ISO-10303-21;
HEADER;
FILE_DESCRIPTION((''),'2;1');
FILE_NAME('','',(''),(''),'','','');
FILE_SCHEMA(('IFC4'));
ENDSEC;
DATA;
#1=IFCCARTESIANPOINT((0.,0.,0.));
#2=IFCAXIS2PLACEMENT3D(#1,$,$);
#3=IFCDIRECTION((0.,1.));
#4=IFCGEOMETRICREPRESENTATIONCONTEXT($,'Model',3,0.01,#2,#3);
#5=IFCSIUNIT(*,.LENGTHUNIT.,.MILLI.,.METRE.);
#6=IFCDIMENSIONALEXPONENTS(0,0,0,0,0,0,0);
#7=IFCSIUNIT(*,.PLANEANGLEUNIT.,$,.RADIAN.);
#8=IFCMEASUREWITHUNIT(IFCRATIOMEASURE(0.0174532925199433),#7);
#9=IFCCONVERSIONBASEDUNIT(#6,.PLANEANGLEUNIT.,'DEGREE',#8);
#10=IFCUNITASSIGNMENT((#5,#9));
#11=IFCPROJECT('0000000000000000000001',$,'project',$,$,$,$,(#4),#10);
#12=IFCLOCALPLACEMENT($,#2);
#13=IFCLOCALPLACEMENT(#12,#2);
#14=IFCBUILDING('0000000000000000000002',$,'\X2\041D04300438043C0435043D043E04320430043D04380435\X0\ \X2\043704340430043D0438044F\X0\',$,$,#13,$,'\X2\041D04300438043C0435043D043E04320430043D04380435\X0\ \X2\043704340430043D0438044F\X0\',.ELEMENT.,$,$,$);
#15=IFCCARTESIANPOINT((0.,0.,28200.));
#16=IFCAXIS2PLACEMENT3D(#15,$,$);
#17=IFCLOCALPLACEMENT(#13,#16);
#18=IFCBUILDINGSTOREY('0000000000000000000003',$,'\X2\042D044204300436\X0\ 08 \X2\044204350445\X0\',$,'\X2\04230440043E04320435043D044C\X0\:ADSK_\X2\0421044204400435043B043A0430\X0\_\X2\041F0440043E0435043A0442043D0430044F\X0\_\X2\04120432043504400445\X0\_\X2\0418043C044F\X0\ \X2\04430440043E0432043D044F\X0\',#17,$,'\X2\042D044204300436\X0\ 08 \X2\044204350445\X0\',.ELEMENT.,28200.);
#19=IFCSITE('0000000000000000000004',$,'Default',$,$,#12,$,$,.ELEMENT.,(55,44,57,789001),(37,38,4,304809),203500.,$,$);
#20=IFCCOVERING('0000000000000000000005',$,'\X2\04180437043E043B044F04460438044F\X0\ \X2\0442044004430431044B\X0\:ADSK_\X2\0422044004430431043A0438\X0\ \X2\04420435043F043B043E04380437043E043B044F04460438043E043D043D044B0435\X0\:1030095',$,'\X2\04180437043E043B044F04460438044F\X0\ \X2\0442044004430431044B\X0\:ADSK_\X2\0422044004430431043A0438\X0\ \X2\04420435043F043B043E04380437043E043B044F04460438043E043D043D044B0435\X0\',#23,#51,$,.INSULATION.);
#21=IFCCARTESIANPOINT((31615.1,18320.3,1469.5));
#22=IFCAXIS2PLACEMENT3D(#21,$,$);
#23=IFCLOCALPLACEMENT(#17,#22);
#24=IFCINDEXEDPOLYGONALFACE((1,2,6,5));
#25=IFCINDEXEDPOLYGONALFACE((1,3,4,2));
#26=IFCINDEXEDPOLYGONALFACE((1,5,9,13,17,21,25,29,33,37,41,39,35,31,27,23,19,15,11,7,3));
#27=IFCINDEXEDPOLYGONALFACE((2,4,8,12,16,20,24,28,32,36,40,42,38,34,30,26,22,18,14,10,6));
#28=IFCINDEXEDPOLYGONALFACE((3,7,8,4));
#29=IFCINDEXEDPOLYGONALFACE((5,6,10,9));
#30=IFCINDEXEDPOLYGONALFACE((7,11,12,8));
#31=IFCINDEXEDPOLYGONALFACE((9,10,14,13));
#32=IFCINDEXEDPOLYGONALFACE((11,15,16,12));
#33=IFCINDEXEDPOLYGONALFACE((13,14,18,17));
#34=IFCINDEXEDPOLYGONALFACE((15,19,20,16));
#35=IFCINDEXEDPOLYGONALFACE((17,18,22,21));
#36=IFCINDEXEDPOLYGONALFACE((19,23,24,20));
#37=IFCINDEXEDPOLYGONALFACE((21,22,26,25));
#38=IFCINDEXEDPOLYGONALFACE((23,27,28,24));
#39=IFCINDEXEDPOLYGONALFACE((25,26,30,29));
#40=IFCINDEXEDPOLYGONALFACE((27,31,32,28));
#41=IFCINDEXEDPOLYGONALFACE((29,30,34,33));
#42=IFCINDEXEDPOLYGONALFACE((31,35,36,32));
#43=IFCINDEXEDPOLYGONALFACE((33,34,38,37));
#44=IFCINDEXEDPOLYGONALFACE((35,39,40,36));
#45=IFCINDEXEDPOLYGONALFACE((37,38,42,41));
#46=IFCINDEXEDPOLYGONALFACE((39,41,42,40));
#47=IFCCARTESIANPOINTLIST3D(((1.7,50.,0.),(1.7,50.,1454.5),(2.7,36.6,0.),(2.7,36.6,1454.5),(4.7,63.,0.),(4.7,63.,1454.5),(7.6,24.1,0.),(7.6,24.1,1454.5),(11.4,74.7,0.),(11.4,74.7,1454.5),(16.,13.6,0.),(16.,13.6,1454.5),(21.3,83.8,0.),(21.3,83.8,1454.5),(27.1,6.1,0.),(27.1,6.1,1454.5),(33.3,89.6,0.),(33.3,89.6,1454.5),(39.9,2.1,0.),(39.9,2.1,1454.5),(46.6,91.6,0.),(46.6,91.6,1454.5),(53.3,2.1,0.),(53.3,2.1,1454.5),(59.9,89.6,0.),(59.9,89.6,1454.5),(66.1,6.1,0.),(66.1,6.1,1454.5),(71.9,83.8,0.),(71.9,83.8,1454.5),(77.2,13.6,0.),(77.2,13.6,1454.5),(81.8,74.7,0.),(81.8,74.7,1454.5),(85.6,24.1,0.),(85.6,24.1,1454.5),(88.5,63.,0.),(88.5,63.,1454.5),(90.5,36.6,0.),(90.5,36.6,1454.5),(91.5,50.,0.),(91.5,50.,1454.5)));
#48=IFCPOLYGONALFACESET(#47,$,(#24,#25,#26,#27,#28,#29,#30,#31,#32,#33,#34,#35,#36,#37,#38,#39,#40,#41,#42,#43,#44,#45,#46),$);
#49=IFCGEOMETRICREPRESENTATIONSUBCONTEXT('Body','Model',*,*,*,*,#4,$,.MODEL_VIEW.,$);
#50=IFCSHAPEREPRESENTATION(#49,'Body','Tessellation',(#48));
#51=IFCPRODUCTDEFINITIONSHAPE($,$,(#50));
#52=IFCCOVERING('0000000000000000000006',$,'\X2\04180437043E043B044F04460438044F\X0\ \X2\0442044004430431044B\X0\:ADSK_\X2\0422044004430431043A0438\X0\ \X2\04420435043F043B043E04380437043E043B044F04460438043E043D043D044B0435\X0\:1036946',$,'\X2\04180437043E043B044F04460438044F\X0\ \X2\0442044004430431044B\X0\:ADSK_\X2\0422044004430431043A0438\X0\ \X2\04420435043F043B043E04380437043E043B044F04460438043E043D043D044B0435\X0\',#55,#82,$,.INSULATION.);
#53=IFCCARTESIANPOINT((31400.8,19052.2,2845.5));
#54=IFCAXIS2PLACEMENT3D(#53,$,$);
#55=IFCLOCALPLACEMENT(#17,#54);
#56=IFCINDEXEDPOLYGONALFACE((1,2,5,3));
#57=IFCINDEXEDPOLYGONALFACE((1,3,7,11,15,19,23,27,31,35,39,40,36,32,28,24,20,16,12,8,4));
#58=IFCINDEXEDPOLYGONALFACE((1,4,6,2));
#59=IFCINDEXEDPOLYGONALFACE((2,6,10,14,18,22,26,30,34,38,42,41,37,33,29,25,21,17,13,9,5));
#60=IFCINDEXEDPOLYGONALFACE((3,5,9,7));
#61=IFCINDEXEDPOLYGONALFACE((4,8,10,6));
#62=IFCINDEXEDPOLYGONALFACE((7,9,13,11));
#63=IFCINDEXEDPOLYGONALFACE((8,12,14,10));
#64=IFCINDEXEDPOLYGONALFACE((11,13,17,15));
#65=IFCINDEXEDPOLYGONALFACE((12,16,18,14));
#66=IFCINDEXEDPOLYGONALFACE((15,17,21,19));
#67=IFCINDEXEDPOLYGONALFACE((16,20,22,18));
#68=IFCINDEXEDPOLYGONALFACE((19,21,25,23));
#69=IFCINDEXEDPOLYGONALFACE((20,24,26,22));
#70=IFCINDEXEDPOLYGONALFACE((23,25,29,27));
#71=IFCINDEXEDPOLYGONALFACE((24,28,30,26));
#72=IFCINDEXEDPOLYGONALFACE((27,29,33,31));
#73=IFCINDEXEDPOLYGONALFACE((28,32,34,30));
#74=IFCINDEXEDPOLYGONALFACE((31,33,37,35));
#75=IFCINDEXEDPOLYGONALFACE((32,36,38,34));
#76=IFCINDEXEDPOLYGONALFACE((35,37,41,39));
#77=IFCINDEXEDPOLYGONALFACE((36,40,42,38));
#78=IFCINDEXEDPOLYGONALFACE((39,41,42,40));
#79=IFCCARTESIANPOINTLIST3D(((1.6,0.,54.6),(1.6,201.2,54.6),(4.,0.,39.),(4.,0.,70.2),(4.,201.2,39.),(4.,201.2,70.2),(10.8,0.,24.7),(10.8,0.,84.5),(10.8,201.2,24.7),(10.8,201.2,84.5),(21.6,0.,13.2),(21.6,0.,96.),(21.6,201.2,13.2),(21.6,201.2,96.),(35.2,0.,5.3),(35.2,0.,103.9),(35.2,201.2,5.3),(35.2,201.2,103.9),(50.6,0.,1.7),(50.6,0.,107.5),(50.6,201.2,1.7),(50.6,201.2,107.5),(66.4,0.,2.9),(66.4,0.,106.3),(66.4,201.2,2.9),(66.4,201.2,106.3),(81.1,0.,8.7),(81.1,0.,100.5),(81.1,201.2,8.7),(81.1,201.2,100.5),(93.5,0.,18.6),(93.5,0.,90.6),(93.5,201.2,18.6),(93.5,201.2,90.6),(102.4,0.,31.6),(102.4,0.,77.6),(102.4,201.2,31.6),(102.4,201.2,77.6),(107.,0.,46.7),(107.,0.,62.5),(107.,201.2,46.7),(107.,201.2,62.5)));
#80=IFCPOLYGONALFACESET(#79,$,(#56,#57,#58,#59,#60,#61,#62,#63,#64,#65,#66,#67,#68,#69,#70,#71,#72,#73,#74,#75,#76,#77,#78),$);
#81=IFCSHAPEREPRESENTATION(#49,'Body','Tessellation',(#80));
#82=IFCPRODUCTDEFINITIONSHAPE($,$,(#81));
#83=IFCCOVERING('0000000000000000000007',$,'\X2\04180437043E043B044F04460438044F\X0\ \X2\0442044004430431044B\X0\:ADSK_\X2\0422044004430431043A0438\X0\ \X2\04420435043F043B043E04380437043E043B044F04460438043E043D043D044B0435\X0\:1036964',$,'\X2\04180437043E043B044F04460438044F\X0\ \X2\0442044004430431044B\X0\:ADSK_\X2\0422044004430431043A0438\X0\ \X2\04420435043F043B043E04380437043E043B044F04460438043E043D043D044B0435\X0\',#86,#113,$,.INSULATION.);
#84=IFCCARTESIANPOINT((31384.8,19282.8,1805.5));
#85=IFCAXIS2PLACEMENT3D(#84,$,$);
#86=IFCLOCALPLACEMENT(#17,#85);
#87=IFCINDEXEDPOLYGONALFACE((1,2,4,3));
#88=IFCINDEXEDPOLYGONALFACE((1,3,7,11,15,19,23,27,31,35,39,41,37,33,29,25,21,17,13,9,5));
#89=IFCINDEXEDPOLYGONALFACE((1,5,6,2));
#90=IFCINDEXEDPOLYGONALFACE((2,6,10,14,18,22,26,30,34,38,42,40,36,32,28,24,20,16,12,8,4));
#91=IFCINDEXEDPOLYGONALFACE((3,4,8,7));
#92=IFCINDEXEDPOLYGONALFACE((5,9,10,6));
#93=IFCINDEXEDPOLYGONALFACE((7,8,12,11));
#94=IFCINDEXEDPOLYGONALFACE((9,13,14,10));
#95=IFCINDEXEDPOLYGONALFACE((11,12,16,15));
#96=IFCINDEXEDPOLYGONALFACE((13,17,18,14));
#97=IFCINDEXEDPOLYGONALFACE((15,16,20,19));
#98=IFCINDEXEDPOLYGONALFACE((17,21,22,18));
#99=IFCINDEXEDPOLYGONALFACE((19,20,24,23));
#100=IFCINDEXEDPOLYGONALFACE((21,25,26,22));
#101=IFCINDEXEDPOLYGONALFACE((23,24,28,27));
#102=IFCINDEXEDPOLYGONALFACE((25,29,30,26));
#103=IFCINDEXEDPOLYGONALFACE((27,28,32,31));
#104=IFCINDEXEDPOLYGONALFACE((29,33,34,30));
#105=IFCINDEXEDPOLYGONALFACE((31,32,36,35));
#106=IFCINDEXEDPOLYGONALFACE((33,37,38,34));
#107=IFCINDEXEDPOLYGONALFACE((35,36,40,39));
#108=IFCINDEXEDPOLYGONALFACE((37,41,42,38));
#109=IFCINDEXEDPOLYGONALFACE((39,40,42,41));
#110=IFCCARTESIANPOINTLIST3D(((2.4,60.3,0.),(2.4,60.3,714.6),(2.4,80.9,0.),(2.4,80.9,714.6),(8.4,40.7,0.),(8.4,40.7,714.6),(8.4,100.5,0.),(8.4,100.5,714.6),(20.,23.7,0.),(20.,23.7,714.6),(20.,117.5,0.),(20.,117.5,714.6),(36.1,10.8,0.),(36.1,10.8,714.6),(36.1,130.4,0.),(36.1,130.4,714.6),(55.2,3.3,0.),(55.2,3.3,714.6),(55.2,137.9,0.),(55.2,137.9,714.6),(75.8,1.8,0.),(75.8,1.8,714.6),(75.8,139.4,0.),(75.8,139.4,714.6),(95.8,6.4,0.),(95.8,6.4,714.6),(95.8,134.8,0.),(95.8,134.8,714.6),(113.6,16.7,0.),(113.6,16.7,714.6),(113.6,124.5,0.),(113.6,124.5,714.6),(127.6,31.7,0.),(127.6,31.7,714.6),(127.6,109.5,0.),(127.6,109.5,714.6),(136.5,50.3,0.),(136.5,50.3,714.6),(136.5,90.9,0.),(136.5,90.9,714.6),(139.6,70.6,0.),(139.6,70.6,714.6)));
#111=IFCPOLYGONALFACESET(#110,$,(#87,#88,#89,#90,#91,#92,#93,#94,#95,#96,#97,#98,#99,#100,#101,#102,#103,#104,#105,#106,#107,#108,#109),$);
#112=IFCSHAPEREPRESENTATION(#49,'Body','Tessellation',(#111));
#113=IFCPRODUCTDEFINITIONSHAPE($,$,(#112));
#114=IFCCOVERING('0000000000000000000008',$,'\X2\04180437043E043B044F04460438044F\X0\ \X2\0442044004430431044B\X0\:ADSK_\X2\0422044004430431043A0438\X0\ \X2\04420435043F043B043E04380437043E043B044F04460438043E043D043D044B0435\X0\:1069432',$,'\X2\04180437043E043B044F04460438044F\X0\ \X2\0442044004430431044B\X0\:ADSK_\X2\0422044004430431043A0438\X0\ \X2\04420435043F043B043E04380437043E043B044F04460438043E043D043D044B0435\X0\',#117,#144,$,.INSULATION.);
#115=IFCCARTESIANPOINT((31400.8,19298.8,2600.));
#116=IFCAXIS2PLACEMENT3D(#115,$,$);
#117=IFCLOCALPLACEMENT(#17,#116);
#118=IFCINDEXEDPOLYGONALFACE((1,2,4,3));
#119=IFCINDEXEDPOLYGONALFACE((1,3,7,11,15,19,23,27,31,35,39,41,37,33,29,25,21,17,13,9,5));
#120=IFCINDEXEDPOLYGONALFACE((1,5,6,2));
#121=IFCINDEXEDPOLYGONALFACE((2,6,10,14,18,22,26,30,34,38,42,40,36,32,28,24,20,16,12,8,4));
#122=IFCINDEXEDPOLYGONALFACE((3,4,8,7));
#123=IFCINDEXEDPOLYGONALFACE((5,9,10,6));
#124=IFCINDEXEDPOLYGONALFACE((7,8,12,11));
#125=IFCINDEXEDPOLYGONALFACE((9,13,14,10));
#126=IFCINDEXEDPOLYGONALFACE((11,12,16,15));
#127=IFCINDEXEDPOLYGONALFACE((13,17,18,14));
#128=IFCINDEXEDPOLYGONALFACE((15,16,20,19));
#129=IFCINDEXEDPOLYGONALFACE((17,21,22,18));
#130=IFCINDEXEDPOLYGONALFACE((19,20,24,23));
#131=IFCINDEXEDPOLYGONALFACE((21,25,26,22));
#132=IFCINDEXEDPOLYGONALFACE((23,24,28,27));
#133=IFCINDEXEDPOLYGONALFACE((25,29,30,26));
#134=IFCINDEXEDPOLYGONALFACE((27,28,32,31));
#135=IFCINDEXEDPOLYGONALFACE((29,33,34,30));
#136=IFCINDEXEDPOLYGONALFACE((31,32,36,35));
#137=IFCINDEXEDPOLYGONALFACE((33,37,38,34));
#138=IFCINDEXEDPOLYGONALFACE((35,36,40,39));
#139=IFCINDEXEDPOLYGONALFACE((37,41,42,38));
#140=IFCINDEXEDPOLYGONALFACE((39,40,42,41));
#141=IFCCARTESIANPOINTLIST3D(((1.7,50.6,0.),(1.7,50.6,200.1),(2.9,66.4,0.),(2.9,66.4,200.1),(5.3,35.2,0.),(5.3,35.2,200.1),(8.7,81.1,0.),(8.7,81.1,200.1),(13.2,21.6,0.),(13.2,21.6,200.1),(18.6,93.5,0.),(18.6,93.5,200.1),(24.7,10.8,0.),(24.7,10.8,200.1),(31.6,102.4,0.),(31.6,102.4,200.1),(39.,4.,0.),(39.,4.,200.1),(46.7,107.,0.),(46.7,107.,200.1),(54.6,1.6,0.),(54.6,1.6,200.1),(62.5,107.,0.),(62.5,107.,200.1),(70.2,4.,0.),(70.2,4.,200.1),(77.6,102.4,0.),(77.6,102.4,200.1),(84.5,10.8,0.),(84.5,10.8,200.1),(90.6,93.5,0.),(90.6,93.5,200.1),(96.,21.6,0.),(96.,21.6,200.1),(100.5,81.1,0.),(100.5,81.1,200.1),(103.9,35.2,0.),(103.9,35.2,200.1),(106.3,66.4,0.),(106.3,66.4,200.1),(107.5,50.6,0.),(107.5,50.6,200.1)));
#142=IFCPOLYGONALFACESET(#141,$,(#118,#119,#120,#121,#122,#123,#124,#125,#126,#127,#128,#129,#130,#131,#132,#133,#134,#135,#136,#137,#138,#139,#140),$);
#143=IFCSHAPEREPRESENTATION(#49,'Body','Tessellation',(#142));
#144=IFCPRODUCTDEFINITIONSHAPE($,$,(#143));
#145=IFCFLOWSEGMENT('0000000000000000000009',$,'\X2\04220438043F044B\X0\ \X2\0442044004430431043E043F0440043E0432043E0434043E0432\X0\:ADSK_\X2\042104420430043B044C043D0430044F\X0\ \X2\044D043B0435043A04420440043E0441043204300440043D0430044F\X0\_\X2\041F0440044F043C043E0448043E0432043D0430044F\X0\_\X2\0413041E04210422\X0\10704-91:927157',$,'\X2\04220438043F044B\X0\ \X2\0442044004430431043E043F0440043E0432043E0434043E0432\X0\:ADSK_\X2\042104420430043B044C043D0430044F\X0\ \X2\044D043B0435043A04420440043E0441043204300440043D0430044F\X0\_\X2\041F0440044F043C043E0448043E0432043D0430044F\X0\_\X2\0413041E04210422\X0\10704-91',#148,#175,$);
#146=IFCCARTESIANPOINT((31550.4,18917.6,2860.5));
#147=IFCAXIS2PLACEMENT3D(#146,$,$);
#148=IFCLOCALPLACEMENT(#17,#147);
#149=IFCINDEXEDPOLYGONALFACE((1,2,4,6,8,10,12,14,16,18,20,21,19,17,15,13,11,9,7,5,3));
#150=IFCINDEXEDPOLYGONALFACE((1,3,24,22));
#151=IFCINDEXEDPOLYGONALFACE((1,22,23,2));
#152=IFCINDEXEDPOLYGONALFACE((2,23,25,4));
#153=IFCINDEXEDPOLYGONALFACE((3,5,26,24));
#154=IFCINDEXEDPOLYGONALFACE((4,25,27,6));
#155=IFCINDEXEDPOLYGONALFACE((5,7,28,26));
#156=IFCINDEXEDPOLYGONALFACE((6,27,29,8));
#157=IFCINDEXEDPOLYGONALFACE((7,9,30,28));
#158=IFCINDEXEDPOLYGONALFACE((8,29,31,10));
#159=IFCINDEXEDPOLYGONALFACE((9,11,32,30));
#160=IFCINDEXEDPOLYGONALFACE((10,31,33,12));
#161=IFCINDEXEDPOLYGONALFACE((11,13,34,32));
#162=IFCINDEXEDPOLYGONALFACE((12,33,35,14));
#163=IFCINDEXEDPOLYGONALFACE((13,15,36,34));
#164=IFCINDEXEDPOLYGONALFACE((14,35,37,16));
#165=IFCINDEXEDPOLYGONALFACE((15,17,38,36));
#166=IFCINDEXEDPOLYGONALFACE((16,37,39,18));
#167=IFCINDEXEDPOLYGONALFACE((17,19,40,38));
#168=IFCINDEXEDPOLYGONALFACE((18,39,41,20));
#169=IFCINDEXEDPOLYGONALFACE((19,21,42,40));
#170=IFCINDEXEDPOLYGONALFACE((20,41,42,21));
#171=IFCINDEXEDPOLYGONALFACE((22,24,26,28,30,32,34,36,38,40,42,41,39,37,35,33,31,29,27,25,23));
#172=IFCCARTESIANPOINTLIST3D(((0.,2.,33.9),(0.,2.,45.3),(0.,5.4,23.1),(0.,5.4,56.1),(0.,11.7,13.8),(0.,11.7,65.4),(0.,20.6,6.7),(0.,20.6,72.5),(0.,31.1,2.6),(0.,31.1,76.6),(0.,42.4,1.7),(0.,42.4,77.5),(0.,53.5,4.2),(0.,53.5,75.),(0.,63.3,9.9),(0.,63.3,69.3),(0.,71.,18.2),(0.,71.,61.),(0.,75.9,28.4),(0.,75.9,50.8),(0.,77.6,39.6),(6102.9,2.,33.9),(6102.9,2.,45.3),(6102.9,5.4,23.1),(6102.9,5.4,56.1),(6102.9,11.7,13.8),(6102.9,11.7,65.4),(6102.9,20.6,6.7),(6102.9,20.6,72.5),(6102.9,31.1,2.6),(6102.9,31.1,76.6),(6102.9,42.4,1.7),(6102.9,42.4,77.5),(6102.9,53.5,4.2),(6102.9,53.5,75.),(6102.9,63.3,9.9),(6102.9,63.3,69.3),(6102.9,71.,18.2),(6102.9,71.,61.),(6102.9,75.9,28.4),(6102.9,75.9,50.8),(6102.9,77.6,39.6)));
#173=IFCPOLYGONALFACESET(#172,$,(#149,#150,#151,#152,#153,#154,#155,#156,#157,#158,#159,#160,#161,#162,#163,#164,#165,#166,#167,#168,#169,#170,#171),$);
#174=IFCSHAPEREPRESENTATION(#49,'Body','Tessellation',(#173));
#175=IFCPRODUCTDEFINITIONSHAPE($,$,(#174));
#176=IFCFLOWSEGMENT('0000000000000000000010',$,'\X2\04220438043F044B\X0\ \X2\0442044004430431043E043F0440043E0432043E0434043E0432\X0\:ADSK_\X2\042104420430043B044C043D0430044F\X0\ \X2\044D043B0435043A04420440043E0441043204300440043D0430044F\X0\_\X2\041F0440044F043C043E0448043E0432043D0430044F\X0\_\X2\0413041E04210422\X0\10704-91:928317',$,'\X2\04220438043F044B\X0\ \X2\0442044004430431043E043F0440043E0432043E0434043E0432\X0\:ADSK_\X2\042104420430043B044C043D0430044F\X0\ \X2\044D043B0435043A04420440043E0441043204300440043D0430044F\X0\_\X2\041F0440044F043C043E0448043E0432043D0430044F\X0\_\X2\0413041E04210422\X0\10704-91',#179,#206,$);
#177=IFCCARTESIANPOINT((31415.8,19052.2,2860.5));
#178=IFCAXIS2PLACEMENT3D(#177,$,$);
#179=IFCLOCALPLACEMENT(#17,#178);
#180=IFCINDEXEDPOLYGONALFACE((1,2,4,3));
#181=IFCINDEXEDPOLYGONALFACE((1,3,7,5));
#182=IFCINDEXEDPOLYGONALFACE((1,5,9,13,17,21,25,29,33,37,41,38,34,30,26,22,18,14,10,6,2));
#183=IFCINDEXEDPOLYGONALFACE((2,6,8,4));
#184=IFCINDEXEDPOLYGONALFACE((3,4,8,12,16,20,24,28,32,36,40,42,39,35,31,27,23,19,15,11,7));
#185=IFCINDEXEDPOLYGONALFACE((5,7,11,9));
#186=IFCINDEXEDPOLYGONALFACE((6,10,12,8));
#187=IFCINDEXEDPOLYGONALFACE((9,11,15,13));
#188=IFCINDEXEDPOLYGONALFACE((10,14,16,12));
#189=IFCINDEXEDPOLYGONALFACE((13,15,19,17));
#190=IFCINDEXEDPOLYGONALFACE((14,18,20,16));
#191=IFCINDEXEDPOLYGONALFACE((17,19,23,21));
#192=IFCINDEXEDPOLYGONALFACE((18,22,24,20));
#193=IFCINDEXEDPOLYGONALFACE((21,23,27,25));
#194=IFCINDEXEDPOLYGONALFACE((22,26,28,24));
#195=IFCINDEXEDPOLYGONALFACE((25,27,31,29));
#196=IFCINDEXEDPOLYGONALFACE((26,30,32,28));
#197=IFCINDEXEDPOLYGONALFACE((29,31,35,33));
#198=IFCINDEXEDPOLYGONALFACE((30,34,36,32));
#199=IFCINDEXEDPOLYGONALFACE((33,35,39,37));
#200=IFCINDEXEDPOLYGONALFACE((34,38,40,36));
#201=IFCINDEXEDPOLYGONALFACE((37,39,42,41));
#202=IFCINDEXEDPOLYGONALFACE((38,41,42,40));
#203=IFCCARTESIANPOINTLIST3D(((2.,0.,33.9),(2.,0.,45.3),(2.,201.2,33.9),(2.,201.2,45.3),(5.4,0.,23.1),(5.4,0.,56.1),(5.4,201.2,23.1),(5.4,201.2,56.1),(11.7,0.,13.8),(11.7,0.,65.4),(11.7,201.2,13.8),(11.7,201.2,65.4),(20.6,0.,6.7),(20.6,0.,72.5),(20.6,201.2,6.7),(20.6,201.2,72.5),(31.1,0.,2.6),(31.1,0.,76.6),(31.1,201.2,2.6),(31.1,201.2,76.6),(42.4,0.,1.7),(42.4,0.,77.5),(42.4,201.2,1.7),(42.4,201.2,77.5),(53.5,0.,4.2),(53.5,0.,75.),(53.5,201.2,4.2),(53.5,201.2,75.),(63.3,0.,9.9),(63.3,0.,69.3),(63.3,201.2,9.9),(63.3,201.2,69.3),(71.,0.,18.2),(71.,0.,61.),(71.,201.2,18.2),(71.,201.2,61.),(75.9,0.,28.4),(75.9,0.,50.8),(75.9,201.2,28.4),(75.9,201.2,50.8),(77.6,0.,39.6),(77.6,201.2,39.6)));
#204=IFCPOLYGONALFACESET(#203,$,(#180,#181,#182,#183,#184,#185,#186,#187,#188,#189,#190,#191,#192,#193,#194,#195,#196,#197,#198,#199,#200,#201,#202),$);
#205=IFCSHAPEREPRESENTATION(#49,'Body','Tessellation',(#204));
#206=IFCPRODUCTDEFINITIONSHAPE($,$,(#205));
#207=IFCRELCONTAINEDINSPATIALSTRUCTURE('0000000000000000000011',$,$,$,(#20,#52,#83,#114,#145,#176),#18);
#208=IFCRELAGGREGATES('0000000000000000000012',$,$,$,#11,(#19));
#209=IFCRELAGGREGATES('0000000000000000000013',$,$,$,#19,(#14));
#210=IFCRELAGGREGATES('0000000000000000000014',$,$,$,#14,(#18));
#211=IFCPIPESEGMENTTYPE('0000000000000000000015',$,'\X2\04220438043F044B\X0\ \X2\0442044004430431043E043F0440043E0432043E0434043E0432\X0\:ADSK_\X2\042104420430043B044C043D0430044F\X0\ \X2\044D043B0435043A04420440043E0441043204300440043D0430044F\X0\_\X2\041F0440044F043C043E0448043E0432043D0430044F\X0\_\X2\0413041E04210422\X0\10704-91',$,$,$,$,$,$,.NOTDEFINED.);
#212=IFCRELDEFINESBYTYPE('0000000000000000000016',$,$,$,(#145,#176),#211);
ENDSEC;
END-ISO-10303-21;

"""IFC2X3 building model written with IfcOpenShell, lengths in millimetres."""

from ifc_helpers import new_model, entity, si_unit, converted_unit, direction, frame, origin, origin_2d_with_axis, place, context, subcontext, project, spatial, circle, extrude, type_object, element, save


model = new_model("IFC2X3")

# Units and contexts
model_context = context("Model", 3, precision=0.01, world=origin(), true_north=direction((0.0, 1.0)))
body_context = subcontext(model_context, "Body", "Model", "MODEL_VIEW")
ifc_project = project(units=[si_unit("LENGTHUNIT", "METRE", prefix="MILLI"), converted_unit("PLANEANGLEUNIT", "DEGREE", entity("IfcRatioMeasure", 0.0174532925199433), si_unit("PLANEANGLEUNIT", "RADIAN"), dimensions=[0, 0, 0, 0, 0, 0, 0])], contexts=[model_context])

# Site, building, storey
site_placement = place(None, origin())
site = spatial("IfcSite", under=ifc_project, at=site_placement, Name="Default", CompositionType="ELEMENT", RefLatitude=(55, 44, 57, 789001), RefLongitude=(37, 38, 4, 304809), RefElevation=203500.0)
building_placement = place(site_placement, origin())
building = spatial("IfcBuilding", under=site, at=building_placement, Name="Наименование здания", LongName="Наименование здания", CompositionType="ELEMENT")
storey_placement = place(building_placement, frame((0.0, 0.0, 28200.0)))
storey = spatial("IfcBuildingStorey", under=building, at=storey_placement, Name="Этаж 08 тех", ObjectType="Уровень:ADSK_Стрелка_Проектная_Вверх_Имя уровня", LongName="Этаж 08 тех", CompositionType="ELEMENT", Elevation=28200.0)

# Coverings
covering_1_placement = place(storey_placement, frame((31615.1, 18320.3, 1469.5)))
element("IfcCovering", 1, at=covering_1_placement, inside=storey, Name="Изоляция трубы:ADSK_Трубки теплоизоляционные:1030095", ObjectType="Изоляция трубы:ADSK_Трубки теплоизоляционные", PredefinedType="INSULATION", context=body_context, shape_type="SweptSolid", body=[
    extrude(circle(Radius=45.0, at=origin_2d_with_axis()), frame((46.6, 46.6, 0.0), z_axis=(0.0, 0.0, 1.0), x_axis=(0.0, 1.0, 0.0)), (0.0, 0.0, 1.0), 1454.5),
])
covering_2_placement = place(storey_placement, frame((31400.8, 19052.2, 2845.5)))
element("IfcCovering", 2, at=covering_2_placement, inside=storey, Name="Изоляция трубы:ADSK_Трубки теплоизоляционные:1036946", ObjectType="Изоляция трубы:ADSK_Трубки теплоизоляционные", PredefinedType="INSULATION", context=body_context, shape_type="SweptSolid", body=[
    extrude(circle(Radius=53.0, at=origin_2d_with_axis()), frame((54.6, 0.0, 54.6), z_axis=(0.0, 1.0, 0.0), x_axis=(-1.0, 0.0, 0.0)), (0.0, 0.0, 1.0), 201.2),
])
covering_3_placement = place(storey_placement, frame((31384.8, 19282.8, 1805.5)))
element("IfcCovering", 3, at=covering_3_placement, inside=storey, Name="Изоляция трубы:ADSK_Трубки теплоизоляционные:1036964", ObjectType="Изоляция трубы:ADSK_Трубки теплоизоляционные", PredefinedType="INSULATION", context=body_context, shape_type="SweptSolid", body=[
    extrude(circle(Radius=69.0, at=origin_2d_with_axis()), frame((70.6, 70.6, 0.0)), (0.0, 0.0, 1.0), 714.6),
])
covering_4_placement = place(storey_placement, frame((31400.8, 19298.8, 2600.0)))
element("IfcCovering", 4, at=covering_4_placement, inside=storey, Name="Изоляция трубы:ADSK_Трубки теплоизоляционные:1069432", ObjectType="Изоляция трубы:ADSK_Трубки теплоизоляционные", PredefinedType="INSULATION", context=body_context, shape_type="SweptSolid", body=[
    extrude(circle(Radius=53.0, at=origin_2d_with_axis()), frame((54.6, 54.6, 0.0), z_axis=(0.0, 0.0, 1.0), x_axis=(0.0, -1.0, 0.0)), (0.0, 0.0, 1.0), 200.1),
])

# Flow segments
pipe_segment_type_1 = type_object("IfcPipeSegmentType", Name="Типы трубопроводов:ADSK_Стальная электросварная_Прямошовная_ГОСТ10704-91", PredefinedType="NOTDEFINED")
flow_segment_1_placement = place(storey_placement, frame((31550.4, 18917.6, 2860.5)))
element("IfcFlowSegment", 5, at=flow_segment_1_placement, inside=storey, type_object=pipe_segment_type_1, Name="Типы трубопроводов:ADSK_Стальная электросварная_Прямошовная_ГОСТ10704-91:927157", ObjectType="Типы трубопроводов:ADSK_Стальная электросварная_Прямошовная_ГОСТ10704-91", context=body_context, shape_type="SweptSolid", body=[
    extrude(circle(Radius=38.0, at=origin_2d_with_axis()), frame((0.0, 39.6, 39.6), z_axis=(1.0, 0.0, 0.0), x_axis=(0.0, 1.0, 0.0)), (0.0, 0.0, 1.0), 6102.9),
])
flow_segment_2_placement = place(storey_placement, frame((31415.8, 19052.2, 2860.5)))
element("IfcFlowSegment", 6, at=flow_segment_2_placement, inside=storey, type_object=pipe_segment_type_1, Name="Типы трубопроводов:ADSK_Стальная электросварная_Прямошовная_ГОСТ10704-91:928317", ObjectType="Типы трубопроводов:ADSK_Стальная электросварная_Прямошовная_ГОСТ10704-91", context=body_context, shape_type="SweptSolid", body=[
    extrude(circle(Radius=38.0, at=origin_2d_with_axis()), frame((39.6, 0.0, 39.6), z_axis=(0.0, 1.0, 0.0), x_axis=(1.0, 0.0, 0.0)), (0.0, 0.0, 1.0), 201.2),
])

save(model, "model.ifc")
